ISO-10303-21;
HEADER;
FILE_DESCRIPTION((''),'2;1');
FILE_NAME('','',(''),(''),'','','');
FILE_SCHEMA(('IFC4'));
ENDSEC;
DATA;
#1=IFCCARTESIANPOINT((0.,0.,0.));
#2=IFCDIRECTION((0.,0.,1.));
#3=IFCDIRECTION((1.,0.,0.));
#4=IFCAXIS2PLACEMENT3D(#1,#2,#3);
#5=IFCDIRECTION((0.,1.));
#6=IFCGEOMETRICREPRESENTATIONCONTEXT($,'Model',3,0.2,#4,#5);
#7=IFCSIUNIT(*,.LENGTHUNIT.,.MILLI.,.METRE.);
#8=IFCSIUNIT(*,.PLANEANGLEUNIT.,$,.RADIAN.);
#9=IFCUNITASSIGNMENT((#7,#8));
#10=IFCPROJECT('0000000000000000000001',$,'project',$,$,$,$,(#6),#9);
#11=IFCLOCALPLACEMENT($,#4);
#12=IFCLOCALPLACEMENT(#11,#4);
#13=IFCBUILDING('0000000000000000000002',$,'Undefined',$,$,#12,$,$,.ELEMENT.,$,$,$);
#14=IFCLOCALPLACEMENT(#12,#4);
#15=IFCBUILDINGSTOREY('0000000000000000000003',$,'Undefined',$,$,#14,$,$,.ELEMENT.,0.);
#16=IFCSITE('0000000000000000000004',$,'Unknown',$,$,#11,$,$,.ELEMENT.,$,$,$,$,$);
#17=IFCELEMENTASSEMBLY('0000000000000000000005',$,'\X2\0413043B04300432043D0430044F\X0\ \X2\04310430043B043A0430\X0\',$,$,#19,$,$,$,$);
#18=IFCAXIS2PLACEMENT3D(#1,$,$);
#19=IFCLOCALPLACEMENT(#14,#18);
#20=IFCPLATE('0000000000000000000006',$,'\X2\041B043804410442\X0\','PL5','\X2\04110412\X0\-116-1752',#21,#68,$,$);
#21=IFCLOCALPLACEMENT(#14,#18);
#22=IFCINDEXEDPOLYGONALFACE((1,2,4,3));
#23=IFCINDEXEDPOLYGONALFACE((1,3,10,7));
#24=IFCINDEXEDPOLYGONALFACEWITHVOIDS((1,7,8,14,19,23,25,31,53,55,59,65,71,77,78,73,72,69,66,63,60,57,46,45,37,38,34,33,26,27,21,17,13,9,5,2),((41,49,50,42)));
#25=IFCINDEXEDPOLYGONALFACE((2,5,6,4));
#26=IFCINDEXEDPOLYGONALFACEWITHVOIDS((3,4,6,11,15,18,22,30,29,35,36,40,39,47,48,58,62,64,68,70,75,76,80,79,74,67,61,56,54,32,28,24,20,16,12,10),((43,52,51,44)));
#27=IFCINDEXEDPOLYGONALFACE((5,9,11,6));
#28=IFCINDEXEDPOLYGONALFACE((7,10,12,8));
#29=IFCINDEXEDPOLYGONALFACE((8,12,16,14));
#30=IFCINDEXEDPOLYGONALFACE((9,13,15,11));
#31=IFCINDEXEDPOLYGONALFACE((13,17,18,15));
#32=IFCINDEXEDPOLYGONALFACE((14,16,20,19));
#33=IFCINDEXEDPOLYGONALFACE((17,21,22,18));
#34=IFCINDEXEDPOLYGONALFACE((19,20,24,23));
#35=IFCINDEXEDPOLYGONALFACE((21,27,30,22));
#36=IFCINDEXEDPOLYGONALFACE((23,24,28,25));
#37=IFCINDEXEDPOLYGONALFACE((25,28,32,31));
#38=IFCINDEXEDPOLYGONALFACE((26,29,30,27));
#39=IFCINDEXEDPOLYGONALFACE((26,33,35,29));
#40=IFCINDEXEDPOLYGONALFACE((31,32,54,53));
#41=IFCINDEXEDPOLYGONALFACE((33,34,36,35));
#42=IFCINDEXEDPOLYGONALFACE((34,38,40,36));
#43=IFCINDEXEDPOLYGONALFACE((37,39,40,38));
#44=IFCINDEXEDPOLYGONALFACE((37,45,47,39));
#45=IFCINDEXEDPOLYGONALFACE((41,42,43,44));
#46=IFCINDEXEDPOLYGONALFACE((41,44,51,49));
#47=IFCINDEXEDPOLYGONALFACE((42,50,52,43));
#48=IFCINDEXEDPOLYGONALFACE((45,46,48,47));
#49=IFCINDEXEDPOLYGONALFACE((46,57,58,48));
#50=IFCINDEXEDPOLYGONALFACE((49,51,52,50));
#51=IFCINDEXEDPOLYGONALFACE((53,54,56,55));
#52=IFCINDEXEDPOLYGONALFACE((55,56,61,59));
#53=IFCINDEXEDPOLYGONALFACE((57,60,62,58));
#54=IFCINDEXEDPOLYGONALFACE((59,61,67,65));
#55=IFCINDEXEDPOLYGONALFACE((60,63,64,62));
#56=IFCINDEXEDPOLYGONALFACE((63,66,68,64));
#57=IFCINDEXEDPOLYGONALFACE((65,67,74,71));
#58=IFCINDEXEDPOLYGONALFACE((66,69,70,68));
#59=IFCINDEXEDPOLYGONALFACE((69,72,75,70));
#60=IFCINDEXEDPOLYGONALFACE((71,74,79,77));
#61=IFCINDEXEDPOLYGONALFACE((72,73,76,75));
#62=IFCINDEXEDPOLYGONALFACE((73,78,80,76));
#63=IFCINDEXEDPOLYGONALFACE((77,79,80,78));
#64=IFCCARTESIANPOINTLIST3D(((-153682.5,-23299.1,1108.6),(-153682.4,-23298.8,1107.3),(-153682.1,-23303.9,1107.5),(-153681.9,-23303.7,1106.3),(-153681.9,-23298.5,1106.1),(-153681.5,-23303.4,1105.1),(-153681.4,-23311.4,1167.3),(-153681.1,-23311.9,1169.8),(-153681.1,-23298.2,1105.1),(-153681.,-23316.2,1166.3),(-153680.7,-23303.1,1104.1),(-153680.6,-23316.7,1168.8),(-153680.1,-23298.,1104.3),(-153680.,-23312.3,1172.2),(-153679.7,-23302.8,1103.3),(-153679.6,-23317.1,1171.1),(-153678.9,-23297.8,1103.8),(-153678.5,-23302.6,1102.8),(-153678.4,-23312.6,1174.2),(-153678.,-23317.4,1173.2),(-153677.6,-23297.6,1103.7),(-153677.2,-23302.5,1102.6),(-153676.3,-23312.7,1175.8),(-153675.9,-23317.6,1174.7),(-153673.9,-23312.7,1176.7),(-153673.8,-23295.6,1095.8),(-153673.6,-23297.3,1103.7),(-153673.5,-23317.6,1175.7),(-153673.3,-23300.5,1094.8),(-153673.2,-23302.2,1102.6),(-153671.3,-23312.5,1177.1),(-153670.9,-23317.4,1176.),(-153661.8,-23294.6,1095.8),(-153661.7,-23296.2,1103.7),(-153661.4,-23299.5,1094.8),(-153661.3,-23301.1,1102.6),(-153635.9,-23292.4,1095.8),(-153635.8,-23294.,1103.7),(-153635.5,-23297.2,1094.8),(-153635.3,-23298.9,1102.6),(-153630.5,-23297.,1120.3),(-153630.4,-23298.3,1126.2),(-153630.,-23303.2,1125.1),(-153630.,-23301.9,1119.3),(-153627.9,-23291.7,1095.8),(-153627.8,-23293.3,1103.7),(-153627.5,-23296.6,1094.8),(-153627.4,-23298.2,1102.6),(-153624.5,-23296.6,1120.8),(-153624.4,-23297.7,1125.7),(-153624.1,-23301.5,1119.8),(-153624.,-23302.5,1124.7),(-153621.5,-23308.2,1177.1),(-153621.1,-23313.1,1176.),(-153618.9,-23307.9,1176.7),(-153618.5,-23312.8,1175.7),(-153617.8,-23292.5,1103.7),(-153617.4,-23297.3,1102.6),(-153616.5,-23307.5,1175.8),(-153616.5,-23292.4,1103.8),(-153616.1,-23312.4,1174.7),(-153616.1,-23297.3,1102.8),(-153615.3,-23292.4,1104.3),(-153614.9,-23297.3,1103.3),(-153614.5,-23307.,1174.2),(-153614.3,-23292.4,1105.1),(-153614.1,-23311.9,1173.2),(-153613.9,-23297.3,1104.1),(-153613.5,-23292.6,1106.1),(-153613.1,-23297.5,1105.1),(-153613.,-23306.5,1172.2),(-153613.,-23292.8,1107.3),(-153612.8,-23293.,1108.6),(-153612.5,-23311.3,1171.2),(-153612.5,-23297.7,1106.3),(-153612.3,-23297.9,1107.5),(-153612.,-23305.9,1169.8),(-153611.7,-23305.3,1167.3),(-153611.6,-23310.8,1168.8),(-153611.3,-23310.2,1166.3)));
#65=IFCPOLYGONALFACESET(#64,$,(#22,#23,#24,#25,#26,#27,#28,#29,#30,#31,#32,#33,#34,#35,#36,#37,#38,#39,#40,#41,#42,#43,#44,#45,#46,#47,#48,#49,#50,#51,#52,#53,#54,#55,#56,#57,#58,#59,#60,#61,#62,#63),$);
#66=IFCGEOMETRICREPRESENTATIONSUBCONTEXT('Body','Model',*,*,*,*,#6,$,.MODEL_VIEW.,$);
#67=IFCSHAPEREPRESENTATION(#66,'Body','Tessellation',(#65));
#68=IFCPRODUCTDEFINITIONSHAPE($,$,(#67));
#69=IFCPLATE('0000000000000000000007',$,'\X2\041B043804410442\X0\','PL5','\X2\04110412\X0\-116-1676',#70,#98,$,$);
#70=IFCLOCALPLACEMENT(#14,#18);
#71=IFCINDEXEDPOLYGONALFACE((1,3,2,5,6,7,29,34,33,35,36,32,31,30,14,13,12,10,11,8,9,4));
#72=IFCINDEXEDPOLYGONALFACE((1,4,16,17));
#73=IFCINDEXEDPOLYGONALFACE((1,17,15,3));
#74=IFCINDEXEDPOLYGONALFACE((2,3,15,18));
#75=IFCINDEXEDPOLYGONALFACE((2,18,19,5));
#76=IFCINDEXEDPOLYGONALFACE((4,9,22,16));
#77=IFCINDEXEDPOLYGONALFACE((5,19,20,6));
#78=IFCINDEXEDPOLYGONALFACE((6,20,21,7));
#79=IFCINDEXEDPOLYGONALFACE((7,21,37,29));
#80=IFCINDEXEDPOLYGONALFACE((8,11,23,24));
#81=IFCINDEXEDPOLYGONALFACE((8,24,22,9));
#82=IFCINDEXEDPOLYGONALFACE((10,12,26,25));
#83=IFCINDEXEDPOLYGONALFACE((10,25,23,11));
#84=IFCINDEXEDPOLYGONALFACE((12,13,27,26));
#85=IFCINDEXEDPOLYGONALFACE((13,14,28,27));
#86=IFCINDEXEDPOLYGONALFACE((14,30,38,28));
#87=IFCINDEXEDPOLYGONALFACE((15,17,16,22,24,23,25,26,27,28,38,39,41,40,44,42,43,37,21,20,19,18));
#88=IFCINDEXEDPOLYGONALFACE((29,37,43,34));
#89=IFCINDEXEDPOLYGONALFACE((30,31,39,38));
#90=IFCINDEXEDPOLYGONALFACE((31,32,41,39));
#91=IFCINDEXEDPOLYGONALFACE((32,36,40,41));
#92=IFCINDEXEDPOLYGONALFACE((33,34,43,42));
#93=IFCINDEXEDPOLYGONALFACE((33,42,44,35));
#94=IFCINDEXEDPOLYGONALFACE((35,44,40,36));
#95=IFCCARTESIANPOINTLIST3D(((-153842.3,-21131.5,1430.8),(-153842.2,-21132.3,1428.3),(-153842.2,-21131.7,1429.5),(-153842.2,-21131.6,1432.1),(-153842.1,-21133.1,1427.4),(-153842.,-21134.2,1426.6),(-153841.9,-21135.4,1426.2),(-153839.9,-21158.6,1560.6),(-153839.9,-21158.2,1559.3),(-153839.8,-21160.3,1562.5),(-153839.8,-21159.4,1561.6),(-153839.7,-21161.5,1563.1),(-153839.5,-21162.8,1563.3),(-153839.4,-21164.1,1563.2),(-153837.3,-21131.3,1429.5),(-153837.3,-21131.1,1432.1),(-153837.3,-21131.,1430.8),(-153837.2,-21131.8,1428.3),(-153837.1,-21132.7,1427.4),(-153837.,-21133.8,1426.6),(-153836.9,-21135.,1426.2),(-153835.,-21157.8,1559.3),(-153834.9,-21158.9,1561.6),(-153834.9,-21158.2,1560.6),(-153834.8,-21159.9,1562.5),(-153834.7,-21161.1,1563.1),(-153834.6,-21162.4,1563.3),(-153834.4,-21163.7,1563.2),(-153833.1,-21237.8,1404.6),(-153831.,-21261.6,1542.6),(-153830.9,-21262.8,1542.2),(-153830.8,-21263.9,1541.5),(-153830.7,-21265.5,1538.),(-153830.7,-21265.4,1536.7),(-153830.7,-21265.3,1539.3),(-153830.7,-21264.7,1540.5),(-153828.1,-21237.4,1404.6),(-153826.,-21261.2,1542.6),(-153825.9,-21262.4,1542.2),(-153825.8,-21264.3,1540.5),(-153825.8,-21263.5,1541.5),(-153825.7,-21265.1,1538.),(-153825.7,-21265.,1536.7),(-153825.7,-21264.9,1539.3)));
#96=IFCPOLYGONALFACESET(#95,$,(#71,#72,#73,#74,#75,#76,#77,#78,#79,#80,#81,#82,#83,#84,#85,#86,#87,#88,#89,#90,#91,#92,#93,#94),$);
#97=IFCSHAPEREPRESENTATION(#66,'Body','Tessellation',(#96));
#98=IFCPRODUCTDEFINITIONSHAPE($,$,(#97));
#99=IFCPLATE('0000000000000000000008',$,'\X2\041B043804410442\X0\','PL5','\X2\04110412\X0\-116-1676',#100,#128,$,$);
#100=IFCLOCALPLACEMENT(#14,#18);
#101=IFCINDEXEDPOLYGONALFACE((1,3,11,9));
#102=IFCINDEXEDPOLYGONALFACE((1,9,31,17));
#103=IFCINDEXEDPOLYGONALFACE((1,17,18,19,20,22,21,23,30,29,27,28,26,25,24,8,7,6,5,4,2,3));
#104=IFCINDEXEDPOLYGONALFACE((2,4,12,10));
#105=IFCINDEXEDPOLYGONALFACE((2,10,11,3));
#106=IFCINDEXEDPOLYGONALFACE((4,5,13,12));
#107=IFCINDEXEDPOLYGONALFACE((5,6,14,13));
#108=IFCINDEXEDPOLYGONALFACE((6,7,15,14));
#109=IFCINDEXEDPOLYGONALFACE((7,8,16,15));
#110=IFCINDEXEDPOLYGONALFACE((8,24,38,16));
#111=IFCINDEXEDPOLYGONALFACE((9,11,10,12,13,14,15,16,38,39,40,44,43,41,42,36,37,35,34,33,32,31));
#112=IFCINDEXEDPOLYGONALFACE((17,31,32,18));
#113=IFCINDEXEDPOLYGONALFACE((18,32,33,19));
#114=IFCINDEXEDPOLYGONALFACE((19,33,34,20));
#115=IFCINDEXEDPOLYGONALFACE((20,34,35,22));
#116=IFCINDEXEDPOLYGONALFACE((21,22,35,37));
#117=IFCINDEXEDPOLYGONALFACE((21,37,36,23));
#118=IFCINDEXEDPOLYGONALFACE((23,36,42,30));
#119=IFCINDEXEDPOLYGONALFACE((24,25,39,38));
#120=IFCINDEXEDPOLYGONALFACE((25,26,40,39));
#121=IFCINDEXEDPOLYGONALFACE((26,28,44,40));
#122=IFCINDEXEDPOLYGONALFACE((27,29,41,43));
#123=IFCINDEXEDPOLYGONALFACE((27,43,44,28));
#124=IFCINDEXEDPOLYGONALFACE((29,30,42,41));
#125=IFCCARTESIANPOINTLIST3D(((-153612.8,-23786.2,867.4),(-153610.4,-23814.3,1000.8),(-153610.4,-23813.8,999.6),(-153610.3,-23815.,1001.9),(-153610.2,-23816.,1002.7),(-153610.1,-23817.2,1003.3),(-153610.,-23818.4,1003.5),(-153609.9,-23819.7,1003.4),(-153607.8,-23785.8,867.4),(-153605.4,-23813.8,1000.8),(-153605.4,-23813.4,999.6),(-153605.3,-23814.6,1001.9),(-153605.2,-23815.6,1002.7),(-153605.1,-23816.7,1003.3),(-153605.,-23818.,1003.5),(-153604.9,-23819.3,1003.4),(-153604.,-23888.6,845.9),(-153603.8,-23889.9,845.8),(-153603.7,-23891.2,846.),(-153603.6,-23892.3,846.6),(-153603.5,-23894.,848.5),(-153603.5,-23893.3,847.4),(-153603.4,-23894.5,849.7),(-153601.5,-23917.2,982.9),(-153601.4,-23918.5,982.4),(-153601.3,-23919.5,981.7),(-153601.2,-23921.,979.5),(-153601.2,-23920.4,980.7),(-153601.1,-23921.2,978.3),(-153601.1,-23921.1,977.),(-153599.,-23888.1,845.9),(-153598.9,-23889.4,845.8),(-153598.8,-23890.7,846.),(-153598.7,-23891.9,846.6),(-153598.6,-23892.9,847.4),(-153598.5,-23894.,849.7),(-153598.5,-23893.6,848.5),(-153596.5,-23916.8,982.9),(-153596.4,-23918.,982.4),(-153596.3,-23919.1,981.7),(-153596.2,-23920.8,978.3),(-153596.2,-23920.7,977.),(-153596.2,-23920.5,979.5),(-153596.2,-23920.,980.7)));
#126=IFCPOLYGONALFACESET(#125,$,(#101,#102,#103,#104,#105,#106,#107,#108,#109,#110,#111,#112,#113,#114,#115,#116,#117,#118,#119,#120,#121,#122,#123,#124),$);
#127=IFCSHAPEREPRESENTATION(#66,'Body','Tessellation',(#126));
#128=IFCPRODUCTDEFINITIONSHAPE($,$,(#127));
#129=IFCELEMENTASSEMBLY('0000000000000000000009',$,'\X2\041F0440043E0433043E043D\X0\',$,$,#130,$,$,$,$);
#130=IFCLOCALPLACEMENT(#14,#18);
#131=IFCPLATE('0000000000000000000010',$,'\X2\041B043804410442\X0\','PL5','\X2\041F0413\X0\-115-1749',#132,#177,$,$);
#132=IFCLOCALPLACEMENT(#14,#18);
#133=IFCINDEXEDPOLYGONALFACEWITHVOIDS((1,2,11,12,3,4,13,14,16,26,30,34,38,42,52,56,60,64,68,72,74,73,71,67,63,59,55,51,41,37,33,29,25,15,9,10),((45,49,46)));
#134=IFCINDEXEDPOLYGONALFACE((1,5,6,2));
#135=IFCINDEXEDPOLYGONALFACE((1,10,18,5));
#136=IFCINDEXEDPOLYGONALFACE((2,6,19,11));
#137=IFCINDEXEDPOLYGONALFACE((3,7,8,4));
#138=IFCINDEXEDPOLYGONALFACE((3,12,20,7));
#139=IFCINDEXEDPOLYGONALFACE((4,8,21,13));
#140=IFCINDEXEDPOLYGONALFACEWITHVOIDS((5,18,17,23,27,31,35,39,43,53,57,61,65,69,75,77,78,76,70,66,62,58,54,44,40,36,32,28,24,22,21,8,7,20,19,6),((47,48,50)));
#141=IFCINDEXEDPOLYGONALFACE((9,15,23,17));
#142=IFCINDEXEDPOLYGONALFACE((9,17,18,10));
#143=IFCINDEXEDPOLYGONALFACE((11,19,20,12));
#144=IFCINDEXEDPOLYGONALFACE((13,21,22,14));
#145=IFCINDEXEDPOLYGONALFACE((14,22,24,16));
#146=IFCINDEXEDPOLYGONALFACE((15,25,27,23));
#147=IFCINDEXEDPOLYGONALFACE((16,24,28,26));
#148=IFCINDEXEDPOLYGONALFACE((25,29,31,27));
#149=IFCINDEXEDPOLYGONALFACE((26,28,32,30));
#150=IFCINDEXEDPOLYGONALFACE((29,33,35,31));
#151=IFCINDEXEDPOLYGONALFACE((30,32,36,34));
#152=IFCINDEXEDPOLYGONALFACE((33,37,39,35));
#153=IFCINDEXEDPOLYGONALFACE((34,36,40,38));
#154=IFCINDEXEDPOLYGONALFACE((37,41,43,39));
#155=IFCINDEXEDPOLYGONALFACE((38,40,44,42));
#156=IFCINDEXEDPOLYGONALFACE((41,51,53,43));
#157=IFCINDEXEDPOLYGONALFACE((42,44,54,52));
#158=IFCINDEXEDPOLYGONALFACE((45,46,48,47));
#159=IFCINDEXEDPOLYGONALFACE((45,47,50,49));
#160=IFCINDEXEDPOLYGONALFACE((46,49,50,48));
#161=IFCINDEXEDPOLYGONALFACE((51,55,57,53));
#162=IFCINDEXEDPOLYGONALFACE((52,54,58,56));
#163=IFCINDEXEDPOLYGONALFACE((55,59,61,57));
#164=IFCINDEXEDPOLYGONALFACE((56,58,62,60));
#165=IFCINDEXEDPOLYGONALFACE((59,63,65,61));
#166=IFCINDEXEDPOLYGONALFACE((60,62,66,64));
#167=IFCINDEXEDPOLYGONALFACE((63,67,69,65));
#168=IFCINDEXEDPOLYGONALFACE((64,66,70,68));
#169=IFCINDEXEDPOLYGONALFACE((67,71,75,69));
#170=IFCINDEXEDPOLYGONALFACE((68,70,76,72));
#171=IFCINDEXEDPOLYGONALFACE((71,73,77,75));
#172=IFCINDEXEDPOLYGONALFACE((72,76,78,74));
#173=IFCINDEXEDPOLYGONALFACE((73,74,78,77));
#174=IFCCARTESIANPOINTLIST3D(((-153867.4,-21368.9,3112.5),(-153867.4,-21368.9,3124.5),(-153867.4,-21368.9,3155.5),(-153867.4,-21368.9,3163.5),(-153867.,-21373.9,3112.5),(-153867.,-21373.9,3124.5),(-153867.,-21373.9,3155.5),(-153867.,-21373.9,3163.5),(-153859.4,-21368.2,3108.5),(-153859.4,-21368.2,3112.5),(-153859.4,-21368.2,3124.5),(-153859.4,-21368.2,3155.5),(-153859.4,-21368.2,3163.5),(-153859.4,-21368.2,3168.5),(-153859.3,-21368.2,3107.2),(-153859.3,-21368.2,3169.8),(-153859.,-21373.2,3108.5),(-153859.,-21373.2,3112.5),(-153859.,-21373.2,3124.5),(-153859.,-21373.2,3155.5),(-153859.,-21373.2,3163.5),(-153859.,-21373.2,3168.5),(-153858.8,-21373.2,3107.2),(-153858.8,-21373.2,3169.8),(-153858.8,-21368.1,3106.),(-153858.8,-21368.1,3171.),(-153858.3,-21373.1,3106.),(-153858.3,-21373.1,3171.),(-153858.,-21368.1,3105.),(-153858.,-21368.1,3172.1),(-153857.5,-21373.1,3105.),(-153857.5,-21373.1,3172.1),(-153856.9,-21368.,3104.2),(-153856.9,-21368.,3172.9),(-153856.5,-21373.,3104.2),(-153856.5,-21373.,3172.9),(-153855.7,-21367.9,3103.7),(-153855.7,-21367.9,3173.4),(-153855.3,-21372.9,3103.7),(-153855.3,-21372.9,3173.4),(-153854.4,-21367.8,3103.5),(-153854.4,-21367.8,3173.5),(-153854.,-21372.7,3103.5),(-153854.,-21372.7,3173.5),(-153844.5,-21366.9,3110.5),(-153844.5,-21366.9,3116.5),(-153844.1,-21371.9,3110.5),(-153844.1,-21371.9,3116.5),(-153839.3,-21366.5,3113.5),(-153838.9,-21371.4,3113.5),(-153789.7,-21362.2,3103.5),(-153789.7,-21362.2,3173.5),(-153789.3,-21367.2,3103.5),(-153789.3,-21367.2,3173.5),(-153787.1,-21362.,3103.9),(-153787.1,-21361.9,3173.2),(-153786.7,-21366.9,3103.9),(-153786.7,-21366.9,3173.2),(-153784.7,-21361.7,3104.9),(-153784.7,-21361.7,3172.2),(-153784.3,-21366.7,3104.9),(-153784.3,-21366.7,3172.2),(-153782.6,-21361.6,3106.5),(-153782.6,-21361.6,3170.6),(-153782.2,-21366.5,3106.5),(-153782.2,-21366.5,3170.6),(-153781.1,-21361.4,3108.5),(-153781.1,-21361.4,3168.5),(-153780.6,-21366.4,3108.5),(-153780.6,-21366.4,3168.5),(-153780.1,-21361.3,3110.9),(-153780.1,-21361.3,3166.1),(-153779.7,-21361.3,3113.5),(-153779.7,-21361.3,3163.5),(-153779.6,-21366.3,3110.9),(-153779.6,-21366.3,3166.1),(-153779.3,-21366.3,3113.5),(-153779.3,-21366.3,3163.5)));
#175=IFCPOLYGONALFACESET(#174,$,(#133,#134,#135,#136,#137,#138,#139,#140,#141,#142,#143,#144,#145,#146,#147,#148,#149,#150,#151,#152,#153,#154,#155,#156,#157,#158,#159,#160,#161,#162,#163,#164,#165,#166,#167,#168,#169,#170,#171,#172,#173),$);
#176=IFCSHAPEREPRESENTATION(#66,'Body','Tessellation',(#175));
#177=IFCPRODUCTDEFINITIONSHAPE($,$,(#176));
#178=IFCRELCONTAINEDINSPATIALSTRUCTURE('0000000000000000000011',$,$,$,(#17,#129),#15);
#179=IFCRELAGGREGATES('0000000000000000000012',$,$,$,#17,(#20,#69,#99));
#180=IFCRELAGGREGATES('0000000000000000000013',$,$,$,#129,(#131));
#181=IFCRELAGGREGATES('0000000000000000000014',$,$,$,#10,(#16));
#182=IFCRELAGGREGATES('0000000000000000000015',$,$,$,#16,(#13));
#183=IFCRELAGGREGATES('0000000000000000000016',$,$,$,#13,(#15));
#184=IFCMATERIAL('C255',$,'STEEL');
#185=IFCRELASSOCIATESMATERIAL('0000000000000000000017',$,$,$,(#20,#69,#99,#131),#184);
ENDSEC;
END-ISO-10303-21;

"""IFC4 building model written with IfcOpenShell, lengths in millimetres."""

from ifc_helpers import new_model, si_unit, direction, frame, origin_with_axes, place, context, subcontext, project, spatial, line, arc, indexed_curve, outline, extrude, material, element, aggregate, save


model = new_model("IFC4")

# Units and contexts
model_context = context("Model", 3, precision=0.2, world=origin_with_axes(), true_north=direction((0.0, 1.0)))
body_context = subcontext(model_context, "Body", "Model", "MODEL_VIEW")
ifc_project = project(units=[si_unit("LENGTHUNIT", "METRE", prefix="MILLI"), si_unit("PLANEANGLEUNIT", "RADIAN")], contexts=[model_context])

# Site, building, storey
site_placement = place(None, origin_with_axes())
site = spatial("IfcSite", under=ifc_project, at=site_placement, Name="Unknown", CompositionType="ELEMENT")
building_placement = place(site_placement, origin_with_axes())
building = spatial("IfcBuilding", under=site, at=building_placement, Name="Undefined", CompositionType="ELEMENT")
storey_placement = place(building_placement, origin_with_axes())
storey = spatial("IfcBuildingStorey", under=building, at=storey_placement, Name="Undefined", CompositionType="ELEMENT", Elevation=0.0)

# Element assemblies, plates, voiding features
ifc_material_1 = material(Name="C255", Category="STEEL")
assembly_1_placement = place(storey_placement, frame((-153839.8, -21131.3, 1498.5), z_axis=(-0.996285, -0.086114, 0.000024), x_axis=(0.084276, -0.975018, -0.205517)))
assembly_1 = element("IfcElementAssembly", 1, at=assembly_1_placement, inside=storey, Name="Главная балка")
plate_1_placement = place(assembly_1_placement, frame((2209.5, 135.0, -40.0), z_axis=(1.0, 0.000054, 0.0), x_axis=(0.0, -0.000054, 1.0)))
plate_1 = element("IfcPlate", 2, at=plate_1_placement, material=ifc_material_1, Name="Лист", Description="PL5", ObjectType="БВ-116-1752", context=body_context, shape_type="SolidModel", body=[
    extrude(outline(indexed_curve([(0.0, 10.0), (2.9, 2.9), (10.0, 0.0), (60.0, 0.0), (67.1, 2.9), (70.0, 10.0), (70.0, 70.0), (68.5, 73.5), (65.0, 75.0), (61.0, 75.0), (61.0, 83.0), (49.0, 83.0), (49.0, 75.0), (23.0, 75.0), (23.0, 83.0), (15.0, 83.0), (15.0, 75.0), (5.0, 75.0), (1.5, 73.5), (0.0, 70.0)], segments=[arc(1, 2, 3), line(3, 4), arc(4, 5, 6), line(6, 7), arc(7, 8, 9), line(9, 10, 11, 12, 13, 14, 15, 16, 17, 18), arc(18, 19, 20), line(20, 1)])), frame((0.0, 0.0, 2.5), z_axis=(0.0, 0.0, 1.0), x_axis=(1.0, 0.0, 0.0)), (0.0, 0.0, -1.0), 5.0),
])
voiding_feature_1_placement = place(plate_1_placement, frame((15.0, 55.0, 10.0), z_axis=(0.007997, -0.999968, -0.000026), x_axis=(0.0, 0.000026, -1.0)))
element("IfcVoidingFeature", 3, at=voiding_feature_1_placement, cuts=plate_1, Name="Балка", ObjectType="(?)", PredefinedType="HOLE", context=body_context, shape_type="SolidModel", body=[
    extrude(outline(indexed_curve([(2.5, -3.0), (3.0, 3.0), (-3.0, 3.0), (-2.5, -3.0)], segments=[line(1, 2, 3, 4, 1)])), frame((0.0, 0.0, 0.0), z_axis=(-1.0, 0.0, 0.0), x_axis=(0.0, 0.0, 1.0)), (0.0, 0.0, -1.0), 20.0),
])
plate_2_placement = place(assembly_1_placement, frame((13.7, 70.0, 0.0), z_axis=(0.0, 0.0, 1.0), x_axis=(0.0, -1.0, 0.0)))
plate_2 = element("IfcPlate", 4, at=plate_2_placement, material=ifc_material_1, Name="Лист", Description="PL5", ObjectType="БВ-116-1676", context=body_context, shape_type="SolidModel", body=[
    extrude(outline(indexed_curve([(0.0, 5.0), (1.5, 1.5), (5.0, 0.0), (135.0, 0.0), (138.5, 1.5), (140.0, 5.0), (140.0, 110.0), (5.0, 110.0), (1.5, 108.5), (0.0, 105.0)], segments=[arc(1, 2, 3), line(3, 4), arc(4, 5, 6), line(6, 7, 8), arc(8, 9, 10), line(10, 1)])), frame((0.0, 0.0, 2.5), z_axis=(0.0, 0.0, 1.0), x_axis=(1.0, 0.0, 0.0)), (0.0, 0.0, -1.0), 5.0),
])
plate_3_placement = place(assembly_1_placement, frame((2847.4, 70.0, 0.0), z_axis=(0.0, 0.0, -1.0), x_axis=(0.0, -1.0, 0.0)))
plate_3 = element("IfcPlate", 5, at=plate_3_placement, material=ifc_material_1, Name="Лист", Description="PL5", ObjectType="БВ-116-1676", context=body_context, shape_type="SolidModel", body=[
    extrude(outline(indexed_curve([(0.0, 5.0), (1.5, 1.5), (5.0, 0.0), (135.0, 0.0), (138.5, 1.5), (140.0, 5.0), (140.0, 110.0), (5.0, 110.0), (1.5, 108.5), (0.0, 105.0)], segments=[arc(1, 2, 3), line(3, 4), arc(4, 5, 6), line(6, 7, 8), arc(8, 9, 10), line(10, 1)])), frame((0.0, 0.0, 2.5), z_axis=(0.0, 0.0, 1.0), x_axis=(1.0, 0.0, 0.0)), (0.0, 0.0, -1.0), 5.0),
])
assembly_2_placement = place(storey_placement, frame((-153899.1, -21374.1, 1131.2), z_axis=(0.086114, -0.996285, 0.0), x_axis=(0.0, 0.0, 1.0)))
assembly_2 = element("IfcElementAssembly", 6, at=assembly_2_placement, inside=storey, Name="Прогон")
plate_4_placement = place(assembly_2_placement, frame((2042.3, -120.0, 0.0), z_axis=(0.0, -0.000057, -1.0), x_axis=(-1.0, 0.000024, 0.0)))
plate_4 = element("IfcPlate", 7, at=plate_4_placement, material=ifc_material_1, Name="Лист", Description="PL5", ObjectType="ПГ-115-1749", context=body_context, shape_type="SolidModel", body=[
    extrude(outline(indexed_curve([(0.0, 10.0), (2.9, 2.9), (10.0, 0.0), (60.0, 0.0), (67.1, 2.9), (70.0, 10.0), (70.0, 75.0), (68.5, 78.5), (65.0, 80.0), (61.0, 80.0), (61.0, 88.0), (49.0, 88.0), (49.0, 80.0), (18.0, 80.0), (18.0, 88.0), (10.0, 88.0), (10.0, 80.0), (5.0, 80.0), (1.5, 78.5), (0.0, 75.0)], segments=[arc(1, 2, 3), line(3, 4), arc(4, 5, 6), line(6, 7), arc(7, 8, 9), line(9, 10, 11, 12, 13, 14, 15, 16, 17, 18), arc(18, 19, 20), line(20, 1)])), frame((0.0, 0.0, 2.5), z_axis=(0.0, 0.0, 1.0), x_axis=(1.0, 0.0, 0.0)), (0.0, 0.0, -1.0), 5.0),
])
voiding_feature_2_placement = place(plate_4_placement, frame((60.0, 65.0, 6.0), z_axis=(-0.000054, -1.0, 0.000034), x_axis=(0.0, -0.000034, -1.0)))
element("IfcVoidingFeature", 8, at=voiding_feature_2_placement, cuts=plate_4, Name="Балка", ObjectType="(?)", PredefinedType="HOLE", context=body_context, shape_type="SolidModel", body=[
    extrude(outline(indexed_curve([(0.0, -3.0), (5.2, 0.0), (0.0, 3.0)], segments=[line(1, 2, 3, 1)])), frame((0.0, 0.0, 0.0), z_axis=(-1.0, 0.0, 0.0), x_axis=(0.0, 0.0, 1.0)), (0.0, 0.0, -1.0), 12.0),
])

aggregate(assembly_1, [plate_1, plate_2, plate_3])
aggregate(assembly_2, [plate_4])

save(model, "model.ifc")
